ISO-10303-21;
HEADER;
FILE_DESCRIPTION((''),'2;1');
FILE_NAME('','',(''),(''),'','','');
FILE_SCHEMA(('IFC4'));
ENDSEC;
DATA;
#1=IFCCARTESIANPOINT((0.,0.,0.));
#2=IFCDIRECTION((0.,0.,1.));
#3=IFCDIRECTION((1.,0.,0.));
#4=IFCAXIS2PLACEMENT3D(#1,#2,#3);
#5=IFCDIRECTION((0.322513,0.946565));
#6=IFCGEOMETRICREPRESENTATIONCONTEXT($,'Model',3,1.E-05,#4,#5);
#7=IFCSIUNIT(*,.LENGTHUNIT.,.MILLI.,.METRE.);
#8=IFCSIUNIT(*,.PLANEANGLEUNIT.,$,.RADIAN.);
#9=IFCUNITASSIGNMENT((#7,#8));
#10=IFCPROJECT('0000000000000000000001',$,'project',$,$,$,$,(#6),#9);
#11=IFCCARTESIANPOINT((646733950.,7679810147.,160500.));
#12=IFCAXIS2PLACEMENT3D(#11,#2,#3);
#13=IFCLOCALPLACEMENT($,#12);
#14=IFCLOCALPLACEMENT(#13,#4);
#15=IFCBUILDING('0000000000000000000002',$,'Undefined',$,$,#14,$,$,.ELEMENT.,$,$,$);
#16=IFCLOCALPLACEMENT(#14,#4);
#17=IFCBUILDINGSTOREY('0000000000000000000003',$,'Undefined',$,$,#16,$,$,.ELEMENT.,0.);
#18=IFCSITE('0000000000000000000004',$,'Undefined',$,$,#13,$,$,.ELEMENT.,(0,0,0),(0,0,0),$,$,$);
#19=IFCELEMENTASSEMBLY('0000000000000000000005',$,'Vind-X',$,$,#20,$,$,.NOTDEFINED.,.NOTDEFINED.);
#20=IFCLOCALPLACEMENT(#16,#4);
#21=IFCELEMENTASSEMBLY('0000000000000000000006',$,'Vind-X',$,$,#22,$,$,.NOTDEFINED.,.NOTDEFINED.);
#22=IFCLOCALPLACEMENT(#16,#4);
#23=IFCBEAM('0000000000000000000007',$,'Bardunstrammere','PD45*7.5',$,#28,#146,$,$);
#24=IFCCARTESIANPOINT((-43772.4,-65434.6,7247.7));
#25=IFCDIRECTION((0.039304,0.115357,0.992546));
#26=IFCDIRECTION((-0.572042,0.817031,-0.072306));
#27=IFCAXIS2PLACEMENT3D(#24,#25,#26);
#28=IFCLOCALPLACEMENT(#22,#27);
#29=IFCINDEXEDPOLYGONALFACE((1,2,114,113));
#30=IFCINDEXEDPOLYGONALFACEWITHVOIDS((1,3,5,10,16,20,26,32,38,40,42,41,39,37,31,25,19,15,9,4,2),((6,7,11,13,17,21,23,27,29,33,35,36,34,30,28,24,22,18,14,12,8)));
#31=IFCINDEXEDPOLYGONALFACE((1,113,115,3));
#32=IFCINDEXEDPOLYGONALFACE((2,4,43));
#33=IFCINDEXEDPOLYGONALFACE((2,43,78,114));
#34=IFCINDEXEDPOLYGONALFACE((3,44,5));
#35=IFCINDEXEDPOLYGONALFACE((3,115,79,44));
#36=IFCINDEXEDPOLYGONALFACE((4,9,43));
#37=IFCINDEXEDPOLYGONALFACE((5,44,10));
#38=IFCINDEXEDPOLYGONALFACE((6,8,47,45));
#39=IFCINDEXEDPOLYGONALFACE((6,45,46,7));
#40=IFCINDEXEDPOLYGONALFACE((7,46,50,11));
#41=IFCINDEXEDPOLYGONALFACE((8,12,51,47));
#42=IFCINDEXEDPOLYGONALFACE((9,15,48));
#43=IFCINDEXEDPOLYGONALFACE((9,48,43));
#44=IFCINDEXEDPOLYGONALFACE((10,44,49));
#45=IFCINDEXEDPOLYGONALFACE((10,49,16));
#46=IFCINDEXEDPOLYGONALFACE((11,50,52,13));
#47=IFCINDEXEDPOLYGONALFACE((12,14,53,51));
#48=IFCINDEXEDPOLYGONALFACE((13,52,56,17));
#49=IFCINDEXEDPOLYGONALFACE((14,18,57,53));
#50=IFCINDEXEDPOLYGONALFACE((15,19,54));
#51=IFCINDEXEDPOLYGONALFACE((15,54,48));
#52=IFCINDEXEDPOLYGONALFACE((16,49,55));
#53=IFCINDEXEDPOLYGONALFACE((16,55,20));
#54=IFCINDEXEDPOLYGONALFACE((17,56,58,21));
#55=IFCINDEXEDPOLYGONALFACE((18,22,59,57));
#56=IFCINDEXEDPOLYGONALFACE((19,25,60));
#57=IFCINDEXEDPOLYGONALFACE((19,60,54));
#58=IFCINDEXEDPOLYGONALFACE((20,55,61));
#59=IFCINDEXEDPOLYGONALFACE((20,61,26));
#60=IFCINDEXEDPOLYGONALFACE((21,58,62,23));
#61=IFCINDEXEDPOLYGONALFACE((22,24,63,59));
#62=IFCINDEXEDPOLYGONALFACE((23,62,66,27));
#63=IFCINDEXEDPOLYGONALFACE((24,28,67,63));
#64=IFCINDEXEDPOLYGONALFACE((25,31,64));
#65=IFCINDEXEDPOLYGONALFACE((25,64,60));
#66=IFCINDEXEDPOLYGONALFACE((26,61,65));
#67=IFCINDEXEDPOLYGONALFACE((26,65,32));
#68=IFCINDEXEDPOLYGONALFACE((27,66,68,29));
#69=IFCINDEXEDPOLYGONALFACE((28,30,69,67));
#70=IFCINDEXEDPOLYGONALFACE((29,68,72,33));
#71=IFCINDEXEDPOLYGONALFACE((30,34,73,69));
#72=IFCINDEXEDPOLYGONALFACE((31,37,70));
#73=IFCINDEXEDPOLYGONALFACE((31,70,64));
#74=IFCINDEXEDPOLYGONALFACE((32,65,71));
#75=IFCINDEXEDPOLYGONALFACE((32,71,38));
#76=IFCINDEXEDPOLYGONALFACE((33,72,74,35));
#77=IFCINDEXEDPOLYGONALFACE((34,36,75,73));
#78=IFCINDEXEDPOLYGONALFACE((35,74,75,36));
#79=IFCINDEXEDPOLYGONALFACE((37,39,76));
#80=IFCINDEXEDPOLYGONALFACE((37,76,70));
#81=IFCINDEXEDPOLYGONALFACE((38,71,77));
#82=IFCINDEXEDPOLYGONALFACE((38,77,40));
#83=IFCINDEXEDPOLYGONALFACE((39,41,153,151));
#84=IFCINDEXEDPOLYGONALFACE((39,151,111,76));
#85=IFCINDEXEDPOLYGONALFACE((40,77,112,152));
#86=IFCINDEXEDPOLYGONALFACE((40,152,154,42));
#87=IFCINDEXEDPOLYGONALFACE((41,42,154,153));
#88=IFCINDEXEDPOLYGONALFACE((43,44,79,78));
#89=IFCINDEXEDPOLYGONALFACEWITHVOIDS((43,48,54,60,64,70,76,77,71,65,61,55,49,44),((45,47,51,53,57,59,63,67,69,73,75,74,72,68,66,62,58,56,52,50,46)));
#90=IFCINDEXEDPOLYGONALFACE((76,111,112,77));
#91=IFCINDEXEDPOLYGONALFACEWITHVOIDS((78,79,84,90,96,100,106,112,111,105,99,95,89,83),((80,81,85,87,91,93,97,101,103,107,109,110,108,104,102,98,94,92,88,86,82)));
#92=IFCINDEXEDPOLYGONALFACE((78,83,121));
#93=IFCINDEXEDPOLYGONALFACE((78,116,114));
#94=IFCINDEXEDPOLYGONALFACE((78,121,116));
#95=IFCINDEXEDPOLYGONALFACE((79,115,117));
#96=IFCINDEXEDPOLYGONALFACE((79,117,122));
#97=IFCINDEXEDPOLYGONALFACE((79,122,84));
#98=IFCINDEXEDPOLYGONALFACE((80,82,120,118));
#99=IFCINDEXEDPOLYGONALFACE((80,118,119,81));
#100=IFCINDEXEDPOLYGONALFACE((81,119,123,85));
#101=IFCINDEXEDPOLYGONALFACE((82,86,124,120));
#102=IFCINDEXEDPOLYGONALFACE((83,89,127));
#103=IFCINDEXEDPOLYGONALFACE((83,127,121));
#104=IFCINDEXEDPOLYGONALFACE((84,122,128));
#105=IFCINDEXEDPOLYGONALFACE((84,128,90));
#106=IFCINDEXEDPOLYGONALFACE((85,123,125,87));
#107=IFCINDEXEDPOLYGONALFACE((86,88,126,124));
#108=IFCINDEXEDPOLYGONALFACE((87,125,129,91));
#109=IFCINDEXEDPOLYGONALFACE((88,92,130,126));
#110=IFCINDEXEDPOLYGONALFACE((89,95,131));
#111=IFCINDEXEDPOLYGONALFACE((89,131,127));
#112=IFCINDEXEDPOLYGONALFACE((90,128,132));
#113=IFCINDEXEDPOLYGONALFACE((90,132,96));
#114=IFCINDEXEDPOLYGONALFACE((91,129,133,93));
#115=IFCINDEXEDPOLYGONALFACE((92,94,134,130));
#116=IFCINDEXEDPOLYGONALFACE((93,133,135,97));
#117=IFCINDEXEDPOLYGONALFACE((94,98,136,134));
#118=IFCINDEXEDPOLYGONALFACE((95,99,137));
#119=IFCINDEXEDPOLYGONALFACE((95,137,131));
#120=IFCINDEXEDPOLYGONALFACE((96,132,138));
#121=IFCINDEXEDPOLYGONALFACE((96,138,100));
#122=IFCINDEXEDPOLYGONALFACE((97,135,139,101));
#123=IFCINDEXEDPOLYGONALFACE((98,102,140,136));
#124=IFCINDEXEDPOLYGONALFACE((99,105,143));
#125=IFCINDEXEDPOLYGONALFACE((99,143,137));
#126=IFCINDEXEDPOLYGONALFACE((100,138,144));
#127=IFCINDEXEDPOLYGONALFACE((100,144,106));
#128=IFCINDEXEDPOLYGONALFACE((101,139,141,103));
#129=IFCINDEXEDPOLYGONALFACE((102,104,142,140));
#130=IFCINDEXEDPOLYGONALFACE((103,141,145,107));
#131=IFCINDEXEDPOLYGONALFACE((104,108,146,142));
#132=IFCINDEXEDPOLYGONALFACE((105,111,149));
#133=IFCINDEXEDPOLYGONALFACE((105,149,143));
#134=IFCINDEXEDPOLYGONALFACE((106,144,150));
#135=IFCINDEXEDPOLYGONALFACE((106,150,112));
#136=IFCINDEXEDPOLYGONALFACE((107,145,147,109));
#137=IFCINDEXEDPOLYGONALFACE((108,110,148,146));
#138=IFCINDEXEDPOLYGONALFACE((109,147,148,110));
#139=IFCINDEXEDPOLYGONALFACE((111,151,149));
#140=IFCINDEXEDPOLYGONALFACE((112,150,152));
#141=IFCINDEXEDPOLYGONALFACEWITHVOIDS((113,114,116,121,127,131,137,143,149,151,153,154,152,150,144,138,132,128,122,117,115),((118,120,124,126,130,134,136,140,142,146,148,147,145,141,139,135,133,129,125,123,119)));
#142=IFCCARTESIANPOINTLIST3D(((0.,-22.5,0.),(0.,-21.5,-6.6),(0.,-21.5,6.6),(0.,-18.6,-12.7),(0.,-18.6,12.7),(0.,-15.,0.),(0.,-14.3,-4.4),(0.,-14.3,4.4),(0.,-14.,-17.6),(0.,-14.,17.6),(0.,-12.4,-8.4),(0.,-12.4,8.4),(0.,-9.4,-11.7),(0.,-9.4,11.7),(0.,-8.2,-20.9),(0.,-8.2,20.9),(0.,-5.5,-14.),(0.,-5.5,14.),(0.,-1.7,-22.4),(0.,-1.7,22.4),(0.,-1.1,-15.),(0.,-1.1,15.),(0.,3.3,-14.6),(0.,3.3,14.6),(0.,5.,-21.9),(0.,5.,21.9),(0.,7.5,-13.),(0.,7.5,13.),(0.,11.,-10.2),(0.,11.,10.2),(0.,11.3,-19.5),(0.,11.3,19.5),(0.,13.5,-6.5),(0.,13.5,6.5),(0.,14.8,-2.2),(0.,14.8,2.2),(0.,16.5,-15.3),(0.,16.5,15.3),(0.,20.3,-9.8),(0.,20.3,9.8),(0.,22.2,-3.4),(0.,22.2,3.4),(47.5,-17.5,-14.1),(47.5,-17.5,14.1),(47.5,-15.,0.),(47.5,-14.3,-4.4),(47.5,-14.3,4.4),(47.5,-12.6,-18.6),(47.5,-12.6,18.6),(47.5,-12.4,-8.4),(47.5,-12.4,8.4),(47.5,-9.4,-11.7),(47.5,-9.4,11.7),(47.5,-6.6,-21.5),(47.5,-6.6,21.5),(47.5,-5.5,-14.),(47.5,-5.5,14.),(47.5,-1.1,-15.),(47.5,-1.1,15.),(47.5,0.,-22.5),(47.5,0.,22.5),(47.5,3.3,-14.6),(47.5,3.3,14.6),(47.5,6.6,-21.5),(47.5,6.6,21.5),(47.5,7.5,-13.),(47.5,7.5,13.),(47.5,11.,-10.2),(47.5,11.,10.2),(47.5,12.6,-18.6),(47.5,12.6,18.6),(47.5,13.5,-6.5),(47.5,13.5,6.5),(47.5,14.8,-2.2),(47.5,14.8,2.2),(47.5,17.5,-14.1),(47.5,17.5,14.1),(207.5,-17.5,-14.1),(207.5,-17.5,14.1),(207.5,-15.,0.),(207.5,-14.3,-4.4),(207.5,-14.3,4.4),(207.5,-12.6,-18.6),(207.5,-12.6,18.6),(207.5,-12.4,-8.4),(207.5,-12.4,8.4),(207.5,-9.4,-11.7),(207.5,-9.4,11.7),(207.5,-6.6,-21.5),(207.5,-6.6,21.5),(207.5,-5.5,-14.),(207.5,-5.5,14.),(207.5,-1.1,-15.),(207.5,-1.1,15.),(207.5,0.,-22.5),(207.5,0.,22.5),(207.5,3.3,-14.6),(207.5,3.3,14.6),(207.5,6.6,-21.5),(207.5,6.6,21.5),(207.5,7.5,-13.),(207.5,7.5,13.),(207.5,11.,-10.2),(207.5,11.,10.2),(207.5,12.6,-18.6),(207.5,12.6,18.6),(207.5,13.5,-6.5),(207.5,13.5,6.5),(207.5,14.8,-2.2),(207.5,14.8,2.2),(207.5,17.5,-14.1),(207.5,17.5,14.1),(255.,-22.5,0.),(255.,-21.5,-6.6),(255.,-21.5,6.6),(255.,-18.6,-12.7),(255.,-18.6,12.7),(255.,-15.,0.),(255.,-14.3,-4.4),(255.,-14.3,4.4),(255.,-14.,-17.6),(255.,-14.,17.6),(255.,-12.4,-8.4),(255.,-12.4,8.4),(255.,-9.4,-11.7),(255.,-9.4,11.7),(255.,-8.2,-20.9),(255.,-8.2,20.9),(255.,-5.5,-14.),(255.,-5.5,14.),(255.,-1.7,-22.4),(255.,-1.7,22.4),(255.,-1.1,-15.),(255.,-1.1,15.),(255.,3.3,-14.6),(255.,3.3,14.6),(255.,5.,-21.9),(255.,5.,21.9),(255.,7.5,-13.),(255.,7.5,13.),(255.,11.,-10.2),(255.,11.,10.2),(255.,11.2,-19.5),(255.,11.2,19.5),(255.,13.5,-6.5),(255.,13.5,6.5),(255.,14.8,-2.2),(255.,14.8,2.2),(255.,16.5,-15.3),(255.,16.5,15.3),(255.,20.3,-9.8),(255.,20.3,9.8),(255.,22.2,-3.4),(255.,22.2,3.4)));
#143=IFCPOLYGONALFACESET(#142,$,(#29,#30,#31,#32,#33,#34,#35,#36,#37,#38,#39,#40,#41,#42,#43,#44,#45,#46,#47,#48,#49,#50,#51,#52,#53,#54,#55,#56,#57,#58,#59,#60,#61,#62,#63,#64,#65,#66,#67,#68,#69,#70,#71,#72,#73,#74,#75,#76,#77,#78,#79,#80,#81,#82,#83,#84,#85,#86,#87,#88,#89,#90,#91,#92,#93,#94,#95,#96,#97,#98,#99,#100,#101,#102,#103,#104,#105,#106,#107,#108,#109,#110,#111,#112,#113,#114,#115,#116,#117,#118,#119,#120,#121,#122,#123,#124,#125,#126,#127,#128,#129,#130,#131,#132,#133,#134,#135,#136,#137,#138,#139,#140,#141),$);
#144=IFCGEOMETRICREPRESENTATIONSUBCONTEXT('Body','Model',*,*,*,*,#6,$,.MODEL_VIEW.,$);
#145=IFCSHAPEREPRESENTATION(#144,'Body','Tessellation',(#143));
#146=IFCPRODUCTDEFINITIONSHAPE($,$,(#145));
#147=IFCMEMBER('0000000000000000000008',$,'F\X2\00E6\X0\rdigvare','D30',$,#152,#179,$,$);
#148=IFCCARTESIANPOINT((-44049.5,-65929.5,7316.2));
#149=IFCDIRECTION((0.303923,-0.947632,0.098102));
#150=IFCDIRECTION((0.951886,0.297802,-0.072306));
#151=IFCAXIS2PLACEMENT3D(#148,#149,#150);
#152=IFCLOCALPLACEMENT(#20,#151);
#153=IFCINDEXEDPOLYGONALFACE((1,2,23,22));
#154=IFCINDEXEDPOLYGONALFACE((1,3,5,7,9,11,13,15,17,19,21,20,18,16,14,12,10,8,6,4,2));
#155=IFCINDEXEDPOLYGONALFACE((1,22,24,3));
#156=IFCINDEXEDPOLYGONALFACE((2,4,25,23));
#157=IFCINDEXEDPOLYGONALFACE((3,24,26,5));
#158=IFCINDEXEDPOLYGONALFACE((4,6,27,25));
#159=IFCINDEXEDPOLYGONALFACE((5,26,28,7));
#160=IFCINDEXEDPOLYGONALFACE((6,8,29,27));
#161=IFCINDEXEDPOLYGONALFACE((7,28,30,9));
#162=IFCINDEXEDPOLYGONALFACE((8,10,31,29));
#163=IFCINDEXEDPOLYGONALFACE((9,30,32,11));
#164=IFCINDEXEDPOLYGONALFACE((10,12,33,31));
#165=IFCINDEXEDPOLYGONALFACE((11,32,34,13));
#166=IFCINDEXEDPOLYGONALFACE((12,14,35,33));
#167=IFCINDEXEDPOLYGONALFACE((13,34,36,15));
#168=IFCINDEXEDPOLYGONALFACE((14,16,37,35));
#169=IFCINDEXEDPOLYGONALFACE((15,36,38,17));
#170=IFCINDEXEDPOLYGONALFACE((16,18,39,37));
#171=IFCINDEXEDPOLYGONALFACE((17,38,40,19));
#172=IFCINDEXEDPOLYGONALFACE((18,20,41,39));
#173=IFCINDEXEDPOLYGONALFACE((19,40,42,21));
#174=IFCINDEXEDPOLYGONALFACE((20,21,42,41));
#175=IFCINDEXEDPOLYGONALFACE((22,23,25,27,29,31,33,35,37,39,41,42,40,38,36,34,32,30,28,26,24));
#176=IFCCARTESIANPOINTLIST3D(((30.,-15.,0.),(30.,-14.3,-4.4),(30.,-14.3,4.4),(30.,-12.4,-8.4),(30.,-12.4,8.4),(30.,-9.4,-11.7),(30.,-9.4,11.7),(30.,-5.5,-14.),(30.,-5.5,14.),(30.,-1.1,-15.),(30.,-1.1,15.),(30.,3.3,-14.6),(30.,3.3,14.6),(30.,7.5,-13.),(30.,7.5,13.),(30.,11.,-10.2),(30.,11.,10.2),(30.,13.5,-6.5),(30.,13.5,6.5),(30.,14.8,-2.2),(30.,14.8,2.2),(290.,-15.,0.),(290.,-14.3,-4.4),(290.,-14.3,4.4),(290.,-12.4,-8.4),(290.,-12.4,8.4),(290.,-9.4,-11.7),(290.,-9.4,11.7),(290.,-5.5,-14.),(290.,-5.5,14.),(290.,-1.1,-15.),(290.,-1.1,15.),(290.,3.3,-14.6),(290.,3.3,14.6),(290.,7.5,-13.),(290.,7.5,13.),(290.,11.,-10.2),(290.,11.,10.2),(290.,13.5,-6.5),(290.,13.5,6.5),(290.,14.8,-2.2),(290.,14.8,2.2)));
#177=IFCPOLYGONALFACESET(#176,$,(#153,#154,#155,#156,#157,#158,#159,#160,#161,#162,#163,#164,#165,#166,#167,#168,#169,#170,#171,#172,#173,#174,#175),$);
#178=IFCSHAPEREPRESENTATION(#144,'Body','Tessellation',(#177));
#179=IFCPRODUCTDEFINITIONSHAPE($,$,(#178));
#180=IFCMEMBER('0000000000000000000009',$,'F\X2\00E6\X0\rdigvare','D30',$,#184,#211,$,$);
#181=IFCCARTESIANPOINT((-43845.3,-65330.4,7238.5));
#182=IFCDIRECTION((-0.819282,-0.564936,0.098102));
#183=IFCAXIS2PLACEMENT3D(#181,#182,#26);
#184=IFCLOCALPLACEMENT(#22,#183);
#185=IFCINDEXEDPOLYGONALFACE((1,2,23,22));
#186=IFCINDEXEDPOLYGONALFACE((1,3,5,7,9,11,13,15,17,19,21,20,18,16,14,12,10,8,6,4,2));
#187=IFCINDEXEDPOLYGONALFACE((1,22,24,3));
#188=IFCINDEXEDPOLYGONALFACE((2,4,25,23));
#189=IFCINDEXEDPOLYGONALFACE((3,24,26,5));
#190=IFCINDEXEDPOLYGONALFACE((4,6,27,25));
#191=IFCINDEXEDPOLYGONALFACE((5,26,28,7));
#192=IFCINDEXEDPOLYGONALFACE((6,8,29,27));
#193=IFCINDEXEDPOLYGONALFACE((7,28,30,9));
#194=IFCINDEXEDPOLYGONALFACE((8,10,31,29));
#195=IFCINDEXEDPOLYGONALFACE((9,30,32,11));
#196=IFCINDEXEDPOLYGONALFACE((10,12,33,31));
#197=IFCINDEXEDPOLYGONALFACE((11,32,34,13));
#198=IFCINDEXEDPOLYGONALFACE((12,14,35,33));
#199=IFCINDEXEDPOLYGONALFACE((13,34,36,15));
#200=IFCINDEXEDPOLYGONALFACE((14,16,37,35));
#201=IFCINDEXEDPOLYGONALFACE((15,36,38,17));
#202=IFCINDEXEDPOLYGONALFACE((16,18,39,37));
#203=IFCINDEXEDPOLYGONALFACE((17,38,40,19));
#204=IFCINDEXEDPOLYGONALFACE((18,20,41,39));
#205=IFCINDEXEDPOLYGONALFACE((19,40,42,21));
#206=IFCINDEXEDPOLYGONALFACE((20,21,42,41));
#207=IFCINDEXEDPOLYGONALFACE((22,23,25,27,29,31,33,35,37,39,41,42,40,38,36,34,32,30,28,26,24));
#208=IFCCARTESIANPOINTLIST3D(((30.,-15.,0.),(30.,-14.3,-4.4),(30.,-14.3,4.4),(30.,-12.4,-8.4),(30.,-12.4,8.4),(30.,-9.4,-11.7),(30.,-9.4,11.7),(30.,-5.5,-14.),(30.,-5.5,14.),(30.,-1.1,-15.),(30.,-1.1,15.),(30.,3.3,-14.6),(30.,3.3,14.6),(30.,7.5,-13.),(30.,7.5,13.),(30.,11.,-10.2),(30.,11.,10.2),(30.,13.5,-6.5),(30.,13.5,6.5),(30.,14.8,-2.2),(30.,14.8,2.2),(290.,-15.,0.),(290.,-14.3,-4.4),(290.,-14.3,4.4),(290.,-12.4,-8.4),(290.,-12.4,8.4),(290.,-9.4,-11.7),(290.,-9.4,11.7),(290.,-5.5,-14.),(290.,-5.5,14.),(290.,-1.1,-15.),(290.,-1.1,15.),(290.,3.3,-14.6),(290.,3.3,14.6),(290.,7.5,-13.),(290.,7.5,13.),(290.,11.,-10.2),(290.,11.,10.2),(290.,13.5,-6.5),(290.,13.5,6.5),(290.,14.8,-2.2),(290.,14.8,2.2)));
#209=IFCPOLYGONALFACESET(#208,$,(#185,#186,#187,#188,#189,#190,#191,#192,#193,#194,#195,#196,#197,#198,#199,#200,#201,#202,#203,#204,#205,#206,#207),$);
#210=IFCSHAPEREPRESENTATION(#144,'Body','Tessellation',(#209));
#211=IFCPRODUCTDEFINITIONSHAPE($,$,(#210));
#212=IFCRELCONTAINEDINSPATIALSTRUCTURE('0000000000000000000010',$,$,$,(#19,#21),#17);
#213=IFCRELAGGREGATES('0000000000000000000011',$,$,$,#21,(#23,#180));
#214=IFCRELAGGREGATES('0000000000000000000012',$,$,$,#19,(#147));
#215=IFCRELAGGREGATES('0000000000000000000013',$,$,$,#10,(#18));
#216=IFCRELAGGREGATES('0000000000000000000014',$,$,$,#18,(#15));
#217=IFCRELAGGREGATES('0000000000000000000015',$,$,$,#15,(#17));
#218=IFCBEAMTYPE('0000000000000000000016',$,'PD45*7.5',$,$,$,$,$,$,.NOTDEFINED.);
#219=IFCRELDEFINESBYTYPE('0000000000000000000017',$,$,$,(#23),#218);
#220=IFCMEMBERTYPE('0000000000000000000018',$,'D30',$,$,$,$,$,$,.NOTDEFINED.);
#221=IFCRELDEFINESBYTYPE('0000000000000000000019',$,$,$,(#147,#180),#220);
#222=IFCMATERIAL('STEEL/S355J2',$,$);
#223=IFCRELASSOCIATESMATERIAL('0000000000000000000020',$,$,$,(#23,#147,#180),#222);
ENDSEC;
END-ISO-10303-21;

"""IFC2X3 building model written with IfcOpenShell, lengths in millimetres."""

from ifc_helpers import new_model, si_unit, direction, frame, origin_with_axes, origin_2d_with_axis, place, context, subcontext, project, spatial, rectangle, circle, hollow_circle, extrude, boolean, clip, halfspace, material, type_object, element, aggregate, save


model = new_model("IFC2X3")

# Units and contexts
model_context = context("Model", 3, precision=1e-05, world=origin_with_axes(), true_north=direction((0.322513, 0.946565)))
body_context = subcontext(model_context, "Body", "Model", "MODEL_VIEW")
ifc_project = project(units=[si_unit("LENGTHUNIT", "METRE", prefix="MILLI"), si_unit("PLANEANGLEUNIT", "RADIAN")], contexts=[model_context])

# Site, building, storey
site_placement = place(None, frame((646733950.0, 7679810147.0, 160500.0), z_axis=(0.0, 0.0, 1.0), x_axis=(1.0, 0.0, 0.0)))
site = spatial("IfcSite", under=ifc_project, at=site_placement, Name="Undefined", CompositionType="ELEMENT", RefLatitude=(0, 0, 0), RefLongitude=(0, 0, 0))
building_placement = place(site_placement, origin_with_axes())
building = spatial("IfcBuilding", under=site, at=building_placement, Name="Undefined", CompositionType="ELEMENT")
storey_placement = place(building_placement, origin_with_axes())
storey = spatial("IfcBuildingStorey", under=building, at=storey_placement, Name="Undefined", CompositionType="ELEMENT", Elevation=0.0)

# Element assemblies, beam
assembly_1_placement = place(storey_placement, origin_with_axes())
assembly_1 = element("IfcElementAssembly", 1, at=assembly_1_placement, inside=storey, Name="Vind-X", AssemblyPlace="NOTDEFINED", PredefinedType="NOTDEFINED")
ifc_material_1 = material(Name="STEEL/S355J2")
beam_type_1 = type_object("IfcBeamType", Name="PD45*7.5", PredefinedType="NOTDEFINED")
assembly_2_placement = place(storey_placement, origin_with_axes())
assembly_2 = element("IfcElementAssembly", 2, at=assembly_2_placement, inside=storey, Name="Vind-X", AssemblyPlace="NOTDEFINED", PredefinedType="NOTDEFINED")
beam_1_placement = place(assembly_2_placement, frame((-43772.4, -65434.6, 7247.7), z_axis=(0.039304, 0.115357, 0.992546), x_axis=(-0.572042, 0.817031, -0.072306)))
beam_1 = element("IfcBeam", 3, at=beam_1_placement, type_object=beam_type_1, material=ifc_material_1, Name="Bardunstrammere", Description="PD45*7.5", context=body_context, shape_type="CSG", body=[
    boolean("DIFFERENCE", extrude(hollow_circle(Radius=22.5, WallThickness=7.5, at=origin_2d_with_axis()), frame((255.0, 0.0, 0.0), z_axis=(-1.0, 0.0, 0.0), x_axis=(0.0, -1.0, 0.0)), (0.0, 0.0, 1.0), 255.0), extrude(rectangle(XDim=35.0, YDim=90.0, at=origin_2d_with_axis()), frame((207.5, 0.0, 0.0), z_axis=(-1.0, 0.0, 0.0), x_axis=(0.0, -1.0, 0.0)), (0.0, 0.0, 1.0), 160.0)),
])

# Members
member_type = type_object("IfcMemberType", Name="D30", PredefinedType="NOTDEFINED")
member_1_placement = place(assembly_1_placement, frame((-44049.5, -65929.5, 7316.2), z_axis=(0.303923, -0.947632, 0.098102), x_axis=(0.951886, 0.297802, -0.072306)))
member_1 = element("IfcMember", 4, at=member_1_placement, type_object=member_type, material=ifc_material_1, Name="Færdigvare", Description="D30", context=body_context, shape_type="Clipping", body=[
    clip(extrude(circle(Radius=15.0, at=origin_2d_with_axis()), frame((290.0, 0.0, 0.0), z_axis=(-1.0, 0.0, 0.0), x_axis=(0.0, -1.0, 0.0)), (0.0, 0.0, 1.0), 290.0), halfspace(frame((30.0, 0.0, -15.0), z_axis=(1.0, 0.0, 0.0), x_axis=(0.0, -1.0, 0.0)), True)),
])
member_2_placement = place(assembly_2_placement, frame((-43845.3, -65330.4, 7238.5), z_axis=(-0.819282, -0.564936, 0.098102), x_axis=(-0.572042, 0.817031, -0.072306)))
member_2 = element("IfcMember", 5, at=member_2_placement, type_object=member_type, material=ifc_material_1, Name="Færdigvare", Description="D30", context=body_context, shape_type="Clipping", body=[
    clip(extrude(circle(Radius=15.0, at=origin_2d_with_axis()), frame((290.0, 0.0, 0.0), z_axis=(-1.0, 0.0, 0.0), x_axis=(0.0, -1.0, 0.0)), (0.0, 0.0, 1.0), 290.4), halfspace(frame((30.0, 0.0, -15.0), z_axis=(1.0, 0.0, 0.0), x_axis=(0.0, -1.0, 0.0)), True)),
])

aggregate(assembly_2, [beam_1, member_2])
aggregate(assembly_1, [member_1])

save(model, "model.ifc")
